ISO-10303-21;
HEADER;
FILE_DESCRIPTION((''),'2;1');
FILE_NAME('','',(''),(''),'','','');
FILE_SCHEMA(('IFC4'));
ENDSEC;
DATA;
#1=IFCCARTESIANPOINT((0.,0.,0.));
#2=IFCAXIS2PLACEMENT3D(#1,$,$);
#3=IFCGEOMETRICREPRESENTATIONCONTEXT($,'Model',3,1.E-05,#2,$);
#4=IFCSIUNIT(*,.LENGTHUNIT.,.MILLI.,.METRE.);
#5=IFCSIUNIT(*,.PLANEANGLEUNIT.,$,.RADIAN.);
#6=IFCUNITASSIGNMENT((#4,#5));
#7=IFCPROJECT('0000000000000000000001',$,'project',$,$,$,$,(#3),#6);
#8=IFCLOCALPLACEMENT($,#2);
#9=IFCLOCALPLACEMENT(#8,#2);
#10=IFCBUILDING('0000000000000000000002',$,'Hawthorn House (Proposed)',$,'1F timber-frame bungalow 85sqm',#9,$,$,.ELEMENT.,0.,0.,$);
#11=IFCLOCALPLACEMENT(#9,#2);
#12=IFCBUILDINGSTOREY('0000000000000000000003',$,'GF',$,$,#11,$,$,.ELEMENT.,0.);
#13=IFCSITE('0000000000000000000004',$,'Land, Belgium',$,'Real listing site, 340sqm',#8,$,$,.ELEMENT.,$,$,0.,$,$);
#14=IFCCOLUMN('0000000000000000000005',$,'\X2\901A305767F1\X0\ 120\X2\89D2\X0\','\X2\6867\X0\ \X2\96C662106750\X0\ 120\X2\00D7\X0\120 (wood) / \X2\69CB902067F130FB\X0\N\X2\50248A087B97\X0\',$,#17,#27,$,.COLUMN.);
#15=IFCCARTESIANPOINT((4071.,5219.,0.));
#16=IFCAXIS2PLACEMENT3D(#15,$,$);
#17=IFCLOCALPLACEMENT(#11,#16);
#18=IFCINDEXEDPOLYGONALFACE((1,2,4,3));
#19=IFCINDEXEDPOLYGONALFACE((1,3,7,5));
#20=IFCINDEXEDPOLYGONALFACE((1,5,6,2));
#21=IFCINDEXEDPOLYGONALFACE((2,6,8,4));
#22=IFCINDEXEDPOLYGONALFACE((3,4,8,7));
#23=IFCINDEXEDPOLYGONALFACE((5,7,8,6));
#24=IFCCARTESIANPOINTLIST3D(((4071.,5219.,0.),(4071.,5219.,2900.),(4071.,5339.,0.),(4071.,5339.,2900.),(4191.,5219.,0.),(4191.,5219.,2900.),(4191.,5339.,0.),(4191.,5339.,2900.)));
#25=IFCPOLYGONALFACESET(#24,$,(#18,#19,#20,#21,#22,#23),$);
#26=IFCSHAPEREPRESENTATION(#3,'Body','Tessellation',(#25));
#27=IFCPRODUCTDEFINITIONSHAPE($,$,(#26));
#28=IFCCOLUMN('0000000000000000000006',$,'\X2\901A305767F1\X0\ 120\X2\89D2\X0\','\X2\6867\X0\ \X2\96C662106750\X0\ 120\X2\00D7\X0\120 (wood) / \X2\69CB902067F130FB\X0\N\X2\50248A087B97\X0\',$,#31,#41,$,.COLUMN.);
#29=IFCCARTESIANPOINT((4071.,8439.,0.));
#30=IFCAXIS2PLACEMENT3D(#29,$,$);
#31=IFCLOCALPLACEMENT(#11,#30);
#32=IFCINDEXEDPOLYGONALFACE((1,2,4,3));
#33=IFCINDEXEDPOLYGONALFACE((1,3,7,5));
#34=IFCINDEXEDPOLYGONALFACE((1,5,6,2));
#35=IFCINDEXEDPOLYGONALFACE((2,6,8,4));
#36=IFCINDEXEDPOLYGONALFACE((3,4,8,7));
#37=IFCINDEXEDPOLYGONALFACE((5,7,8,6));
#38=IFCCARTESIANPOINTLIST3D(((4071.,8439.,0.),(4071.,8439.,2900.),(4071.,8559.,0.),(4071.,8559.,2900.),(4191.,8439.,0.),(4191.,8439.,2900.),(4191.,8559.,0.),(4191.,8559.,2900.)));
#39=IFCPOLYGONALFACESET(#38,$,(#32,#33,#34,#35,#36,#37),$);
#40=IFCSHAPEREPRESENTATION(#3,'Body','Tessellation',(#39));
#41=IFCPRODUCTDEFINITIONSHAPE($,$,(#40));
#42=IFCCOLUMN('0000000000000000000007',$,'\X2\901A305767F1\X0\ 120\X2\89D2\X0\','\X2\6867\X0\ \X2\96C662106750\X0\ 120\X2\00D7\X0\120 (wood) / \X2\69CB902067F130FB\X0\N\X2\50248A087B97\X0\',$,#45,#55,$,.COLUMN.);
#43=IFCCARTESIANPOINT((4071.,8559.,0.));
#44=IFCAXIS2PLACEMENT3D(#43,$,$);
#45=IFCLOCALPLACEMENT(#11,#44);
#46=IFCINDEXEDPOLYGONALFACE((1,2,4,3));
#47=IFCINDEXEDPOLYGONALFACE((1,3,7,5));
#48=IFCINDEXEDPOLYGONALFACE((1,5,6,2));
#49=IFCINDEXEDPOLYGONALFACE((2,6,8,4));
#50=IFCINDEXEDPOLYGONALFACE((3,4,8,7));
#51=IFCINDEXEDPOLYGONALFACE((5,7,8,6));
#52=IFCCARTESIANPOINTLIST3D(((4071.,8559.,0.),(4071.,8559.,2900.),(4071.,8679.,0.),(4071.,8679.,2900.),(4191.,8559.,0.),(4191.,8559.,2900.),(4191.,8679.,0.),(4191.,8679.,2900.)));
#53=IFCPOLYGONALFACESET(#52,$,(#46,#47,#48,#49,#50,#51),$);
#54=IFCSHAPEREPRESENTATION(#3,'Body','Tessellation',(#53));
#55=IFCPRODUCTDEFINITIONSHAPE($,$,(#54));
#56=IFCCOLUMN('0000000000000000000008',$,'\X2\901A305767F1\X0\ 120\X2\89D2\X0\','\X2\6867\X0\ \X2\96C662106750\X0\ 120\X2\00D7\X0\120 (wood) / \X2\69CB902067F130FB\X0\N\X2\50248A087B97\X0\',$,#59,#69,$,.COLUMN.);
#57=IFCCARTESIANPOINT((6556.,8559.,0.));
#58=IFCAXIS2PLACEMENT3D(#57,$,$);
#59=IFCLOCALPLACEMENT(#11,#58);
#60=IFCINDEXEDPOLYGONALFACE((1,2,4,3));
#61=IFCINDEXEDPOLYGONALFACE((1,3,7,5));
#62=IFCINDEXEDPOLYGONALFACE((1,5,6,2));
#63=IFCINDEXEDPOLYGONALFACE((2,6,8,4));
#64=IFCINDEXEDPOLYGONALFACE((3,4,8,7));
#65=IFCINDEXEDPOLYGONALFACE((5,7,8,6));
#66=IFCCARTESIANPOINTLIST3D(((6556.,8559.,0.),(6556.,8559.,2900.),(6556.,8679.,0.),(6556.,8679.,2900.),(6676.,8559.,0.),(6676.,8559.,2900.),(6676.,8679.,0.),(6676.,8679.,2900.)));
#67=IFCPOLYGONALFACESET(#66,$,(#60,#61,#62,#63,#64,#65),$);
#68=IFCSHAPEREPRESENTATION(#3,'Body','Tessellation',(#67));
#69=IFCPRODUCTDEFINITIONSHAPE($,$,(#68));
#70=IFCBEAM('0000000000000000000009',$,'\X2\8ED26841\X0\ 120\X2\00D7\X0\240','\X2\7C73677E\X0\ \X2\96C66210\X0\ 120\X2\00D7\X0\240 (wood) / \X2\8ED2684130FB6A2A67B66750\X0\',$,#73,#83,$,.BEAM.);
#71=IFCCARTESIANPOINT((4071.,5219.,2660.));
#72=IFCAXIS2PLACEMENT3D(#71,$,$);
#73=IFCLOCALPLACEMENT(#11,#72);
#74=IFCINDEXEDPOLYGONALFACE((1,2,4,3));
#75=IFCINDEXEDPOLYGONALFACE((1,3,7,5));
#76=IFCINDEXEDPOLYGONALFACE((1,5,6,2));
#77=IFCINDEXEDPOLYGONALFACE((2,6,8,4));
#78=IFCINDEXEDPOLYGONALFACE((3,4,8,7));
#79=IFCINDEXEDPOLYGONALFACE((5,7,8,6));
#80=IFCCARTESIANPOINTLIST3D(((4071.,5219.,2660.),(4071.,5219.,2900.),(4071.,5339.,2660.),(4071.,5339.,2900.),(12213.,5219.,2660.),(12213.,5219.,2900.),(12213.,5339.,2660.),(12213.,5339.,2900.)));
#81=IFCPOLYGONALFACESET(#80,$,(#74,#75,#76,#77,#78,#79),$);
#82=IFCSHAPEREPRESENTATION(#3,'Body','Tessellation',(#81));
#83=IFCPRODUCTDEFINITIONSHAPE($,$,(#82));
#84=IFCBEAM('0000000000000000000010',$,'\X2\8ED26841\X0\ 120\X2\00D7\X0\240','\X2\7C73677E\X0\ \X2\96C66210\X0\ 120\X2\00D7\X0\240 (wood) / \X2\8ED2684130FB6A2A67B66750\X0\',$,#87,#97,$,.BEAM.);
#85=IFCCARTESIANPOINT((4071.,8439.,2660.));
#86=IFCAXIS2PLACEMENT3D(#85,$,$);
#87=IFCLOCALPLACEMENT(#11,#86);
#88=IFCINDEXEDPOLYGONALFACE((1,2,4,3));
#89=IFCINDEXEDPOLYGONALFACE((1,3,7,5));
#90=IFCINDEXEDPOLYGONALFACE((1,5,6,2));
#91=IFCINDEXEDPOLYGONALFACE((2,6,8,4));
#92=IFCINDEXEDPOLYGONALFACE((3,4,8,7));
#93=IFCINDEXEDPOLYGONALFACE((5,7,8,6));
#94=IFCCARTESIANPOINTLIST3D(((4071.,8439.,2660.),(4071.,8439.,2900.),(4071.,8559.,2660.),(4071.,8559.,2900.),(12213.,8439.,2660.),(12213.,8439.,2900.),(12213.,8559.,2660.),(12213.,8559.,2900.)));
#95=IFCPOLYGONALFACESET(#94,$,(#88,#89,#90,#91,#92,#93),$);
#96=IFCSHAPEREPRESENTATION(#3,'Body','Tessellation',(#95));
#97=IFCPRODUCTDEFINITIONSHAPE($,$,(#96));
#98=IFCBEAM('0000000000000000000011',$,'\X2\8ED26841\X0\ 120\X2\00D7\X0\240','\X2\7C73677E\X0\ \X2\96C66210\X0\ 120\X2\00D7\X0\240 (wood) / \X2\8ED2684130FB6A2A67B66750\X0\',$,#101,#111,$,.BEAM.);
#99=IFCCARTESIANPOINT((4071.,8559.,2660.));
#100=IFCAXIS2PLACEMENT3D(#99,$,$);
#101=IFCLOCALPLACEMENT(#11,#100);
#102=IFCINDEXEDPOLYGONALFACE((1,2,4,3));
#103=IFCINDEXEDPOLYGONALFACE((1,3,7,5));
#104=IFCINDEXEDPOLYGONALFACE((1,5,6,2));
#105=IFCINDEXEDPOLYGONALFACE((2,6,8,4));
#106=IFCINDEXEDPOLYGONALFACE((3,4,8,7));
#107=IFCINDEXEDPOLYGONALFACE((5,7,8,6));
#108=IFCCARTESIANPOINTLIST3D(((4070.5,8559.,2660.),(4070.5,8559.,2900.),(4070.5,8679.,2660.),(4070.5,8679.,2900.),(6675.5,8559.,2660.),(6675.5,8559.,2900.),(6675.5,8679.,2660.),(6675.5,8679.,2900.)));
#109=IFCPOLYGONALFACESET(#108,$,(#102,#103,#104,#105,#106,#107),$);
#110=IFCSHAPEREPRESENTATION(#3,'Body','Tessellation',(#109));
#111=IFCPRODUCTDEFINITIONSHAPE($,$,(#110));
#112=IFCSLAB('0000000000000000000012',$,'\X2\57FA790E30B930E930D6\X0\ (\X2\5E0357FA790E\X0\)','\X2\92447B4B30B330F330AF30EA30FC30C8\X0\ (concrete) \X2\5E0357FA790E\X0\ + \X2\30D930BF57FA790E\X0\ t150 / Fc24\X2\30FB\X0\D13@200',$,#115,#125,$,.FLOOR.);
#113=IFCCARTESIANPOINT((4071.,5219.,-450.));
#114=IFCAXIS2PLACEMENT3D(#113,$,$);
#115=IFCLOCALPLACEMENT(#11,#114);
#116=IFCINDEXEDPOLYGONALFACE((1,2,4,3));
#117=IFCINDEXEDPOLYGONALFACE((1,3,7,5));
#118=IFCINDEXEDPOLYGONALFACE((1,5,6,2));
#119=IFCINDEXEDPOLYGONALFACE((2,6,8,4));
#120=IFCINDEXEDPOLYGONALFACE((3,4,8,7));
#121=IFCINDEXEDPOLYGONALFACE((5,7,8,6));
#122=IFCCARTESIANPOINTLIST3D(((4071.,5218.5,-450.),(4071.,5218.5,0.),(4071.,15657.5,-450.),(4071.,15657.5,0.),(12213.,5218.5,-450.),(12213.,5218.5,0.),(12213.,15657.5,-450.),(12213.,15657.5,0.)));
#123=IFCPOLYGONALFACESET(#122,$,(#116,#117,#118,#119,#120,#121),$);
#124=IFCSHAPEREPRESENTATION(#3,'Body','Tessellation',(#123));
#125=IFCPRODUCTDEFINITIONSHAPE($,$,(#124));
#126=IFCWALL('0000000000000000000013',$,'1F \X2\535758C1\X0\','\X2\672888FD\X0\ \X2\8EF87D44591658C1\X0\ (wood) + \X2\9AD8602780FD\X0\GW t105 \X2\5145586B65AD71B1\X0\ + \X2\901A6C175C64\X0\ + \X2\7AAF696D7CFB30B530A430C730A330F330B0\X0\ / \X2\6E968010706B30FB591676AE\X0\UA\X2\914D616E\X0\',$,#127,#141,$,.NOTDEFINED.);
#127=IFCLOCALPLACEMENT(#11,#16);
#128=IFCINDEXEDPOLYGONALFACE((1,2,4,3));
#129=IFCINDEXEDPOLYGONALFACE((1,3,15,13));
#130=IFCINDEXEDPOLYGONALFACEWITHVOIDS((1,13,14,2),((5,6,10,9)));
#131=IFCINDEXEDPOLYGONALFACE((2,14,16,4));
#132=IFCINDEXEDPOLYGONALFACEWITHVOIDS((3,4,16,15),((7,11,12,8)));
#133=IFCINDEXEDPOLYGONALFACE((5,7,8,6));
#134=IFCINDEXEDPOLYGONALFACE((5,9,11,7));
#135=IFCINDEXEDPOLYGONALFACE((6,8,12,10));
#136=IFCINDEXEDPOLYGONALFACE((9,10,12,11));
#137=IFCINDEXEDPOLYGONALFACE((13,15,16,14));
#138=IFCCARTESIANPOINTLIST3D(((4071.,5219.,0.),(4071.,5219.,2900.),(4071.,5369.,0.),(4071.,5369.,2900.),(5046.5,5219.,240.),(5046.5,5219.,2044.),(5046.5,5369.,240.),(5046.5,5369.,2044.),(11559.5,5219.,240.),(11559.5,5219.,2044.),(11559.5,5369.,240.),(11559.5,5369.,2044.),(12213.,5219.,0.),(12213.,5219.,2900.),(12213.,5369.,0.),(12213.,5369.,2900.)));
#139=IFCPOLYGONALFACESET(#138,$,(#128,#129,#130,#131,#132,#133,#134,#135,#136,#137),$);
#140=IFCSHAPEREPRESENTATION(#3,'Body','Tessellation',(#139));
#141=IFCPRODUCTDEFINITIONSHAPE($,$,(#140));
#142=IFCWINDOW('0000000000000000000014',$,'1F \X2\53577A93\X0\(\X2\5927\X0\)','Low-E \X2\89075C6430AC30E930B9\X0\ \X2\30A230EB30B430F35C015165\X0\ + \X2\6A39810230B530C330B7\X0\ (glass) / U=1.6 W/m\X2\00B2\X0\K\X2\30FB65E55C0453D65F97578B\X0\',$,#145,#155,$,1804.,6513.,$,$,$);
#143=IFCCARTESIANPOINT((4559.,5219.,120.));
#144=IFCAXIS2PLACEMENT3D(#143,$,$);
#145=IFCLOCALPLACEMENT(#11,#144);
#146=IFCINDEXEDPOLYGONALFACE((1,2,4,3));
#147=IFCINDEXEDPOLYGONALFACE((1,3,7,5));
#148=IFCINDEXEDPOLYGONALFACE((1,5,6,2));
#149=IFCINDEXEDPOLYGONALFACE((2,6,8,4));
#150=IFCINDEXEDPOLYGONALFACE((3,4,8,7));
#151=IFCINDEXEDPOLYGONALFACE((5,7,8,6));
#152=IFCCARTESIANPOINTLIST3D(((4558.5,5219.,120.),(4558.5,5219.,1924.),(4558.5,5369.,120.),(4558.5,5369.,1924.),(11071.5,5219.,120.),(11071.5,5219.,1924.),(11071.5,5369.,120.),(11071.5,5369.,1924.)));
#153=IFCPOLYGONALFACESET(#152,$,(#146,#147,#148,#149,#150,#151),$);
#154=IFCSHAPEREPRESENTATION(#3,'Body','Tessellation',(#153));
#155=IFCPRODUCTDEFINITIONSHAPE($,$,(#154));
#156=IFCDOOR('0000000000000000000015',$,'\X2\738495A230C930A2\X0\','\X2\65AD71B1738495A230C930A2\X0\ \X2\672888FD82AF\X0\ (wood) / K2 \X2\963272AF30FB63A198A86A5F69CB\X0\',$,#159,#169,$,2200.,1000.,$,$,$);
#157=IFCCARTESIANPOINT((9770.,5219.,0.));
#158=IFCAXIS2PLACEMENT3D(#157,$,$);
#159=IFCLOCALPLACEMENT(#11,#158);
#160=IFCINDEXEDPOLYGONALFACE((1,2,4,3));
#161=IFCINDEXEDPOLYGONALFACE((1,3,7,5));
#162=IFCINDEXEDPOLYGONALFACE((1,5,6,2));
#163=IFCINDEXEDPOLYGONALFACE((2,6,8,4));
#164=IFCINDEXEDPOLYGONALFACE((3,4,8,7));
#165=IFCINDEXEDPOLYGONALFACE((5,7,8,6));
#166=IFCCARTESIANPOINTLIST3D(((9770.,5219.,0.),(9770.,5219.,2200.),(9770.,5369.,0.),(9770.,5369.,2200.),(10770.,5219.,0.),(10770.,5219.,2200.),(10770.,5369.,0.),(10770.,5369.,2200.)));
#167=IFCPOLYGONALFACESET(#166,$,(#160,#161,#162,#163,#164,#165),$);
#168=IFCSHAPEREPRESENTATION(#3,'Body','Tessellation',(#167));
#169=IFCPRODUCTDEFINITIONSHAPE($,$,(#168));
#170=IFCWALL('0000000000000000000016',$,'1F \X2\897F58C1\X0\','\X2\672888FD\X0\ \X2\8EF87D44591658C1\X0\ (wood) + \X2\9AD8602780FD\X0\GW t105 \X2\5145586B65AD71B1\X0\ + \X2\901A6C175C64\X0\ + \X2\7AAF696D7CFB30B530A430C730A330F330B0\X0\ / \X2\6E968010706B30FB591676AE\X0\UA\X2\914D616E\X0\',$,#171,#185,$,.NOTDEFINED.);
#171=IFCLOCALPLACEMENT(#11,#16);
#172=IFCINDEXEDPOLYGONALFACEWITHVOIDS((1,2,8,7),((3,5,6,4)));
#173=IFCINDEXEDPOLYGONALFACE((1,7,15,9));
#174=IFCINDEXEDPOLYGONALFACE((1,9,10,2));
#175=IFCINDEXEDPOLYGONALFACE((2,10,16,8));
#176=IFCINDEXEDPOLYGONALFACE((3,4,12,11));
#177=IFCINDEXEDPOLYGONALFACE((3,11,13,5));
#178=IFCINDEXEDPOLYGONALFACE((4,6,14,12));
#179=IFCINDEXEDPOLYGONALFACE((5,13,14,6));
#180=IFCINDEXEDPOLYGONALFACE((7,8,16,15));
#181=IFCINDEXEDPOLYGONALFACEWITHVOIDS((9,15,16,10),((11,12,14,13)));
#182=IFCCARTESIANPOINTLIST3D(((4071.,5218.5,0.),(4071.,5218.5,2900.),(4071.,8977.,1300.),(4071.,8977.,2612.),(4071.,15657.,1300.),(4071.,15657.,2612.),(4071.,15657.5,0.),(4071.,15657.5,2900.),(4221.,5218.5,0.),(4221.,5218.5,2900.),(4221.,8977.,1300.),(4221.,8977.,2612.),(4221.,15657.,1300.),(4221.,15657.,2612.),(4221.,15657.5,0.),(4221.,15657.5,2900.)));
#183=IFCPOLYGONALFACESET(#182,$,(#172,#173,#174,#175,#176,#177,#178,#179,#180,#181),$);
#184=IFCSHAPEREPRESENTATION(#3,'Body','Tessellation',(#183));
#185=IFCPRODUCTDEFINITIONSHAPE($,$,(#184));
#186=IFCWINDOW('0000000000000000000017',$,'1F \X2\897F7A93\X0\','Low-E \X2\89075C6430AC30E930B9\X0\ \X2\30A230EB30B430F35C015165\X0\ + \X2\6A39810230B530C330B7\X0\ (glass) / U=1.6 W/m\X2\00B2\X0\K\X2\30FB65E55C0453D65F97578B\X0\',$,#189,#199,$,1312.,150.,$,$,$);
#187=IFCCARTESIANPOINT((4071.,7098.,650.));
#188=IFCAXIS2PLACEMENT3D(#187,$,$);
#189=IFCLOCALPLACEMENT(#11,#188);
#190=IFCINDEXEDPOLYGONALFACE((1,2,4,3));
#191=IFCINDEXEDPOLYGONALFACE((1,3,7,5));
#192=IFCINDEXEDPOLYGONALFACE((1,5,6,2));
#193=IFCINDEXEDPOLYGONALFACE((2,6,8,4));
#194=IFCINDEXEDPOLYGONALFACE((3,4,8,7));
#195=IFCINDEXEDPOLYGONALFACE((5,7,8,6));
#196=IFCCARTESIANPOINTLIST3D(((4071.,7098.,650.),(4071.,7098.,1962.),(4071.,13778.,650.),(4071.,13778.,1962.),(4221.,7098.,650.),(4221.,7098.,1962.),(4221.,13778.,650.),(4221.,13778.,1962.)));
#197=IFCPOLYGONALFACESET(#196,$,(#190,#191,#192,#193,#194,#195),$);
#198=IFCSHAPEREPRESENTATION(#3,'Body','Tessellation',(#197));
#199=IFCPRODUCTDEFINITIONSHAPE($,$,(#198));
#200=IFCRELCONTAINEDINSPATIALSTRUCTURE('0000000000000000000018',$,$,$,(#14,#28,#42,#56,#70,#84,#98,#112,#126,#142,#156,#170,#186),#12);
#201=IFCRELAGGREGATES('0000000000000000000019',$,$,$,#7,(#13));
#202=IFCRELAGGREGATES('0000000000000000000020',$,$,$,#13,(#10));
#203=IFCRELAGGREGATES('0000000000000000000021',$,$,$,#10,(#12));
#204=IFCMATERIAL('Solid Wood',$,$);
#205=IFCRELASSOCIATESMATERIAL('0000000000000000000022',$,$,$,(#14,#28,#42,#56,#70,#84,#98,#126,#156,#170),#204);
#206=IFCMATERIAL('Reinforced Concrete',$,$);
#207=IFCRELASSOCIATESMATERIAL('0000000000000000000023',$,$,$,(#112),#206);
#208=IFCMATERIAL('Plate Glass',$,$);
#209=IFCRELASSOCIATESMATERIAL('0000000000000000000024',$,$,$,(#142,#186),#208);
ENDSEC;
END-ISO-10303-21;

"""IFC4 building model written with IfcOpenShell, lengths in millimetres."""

from ifc_helpers import new_model, si_unit, frame, frame_2d, origin, place, context, project, spatial, rectangle, extrude, material, element, fill, save


model = new_model("IFC4")

# Units and contexts
model_context = context("Model", 3, precision=1e-05, world=origin())
ifc_project = project(units=[si_unit("LENGTHUNIT", "METRE", prefix="MILLI"), si_unit("PLANEANGLEUNIT", "RADIAN")], contexts=[model_context])

# Site, building, storey
site_placement = place(None, origin())
site = spatial("IfcSite", under=ifc_project, at=site_placement, Name="Land, Belgium", ObjectType="Real listing site, 340sqm", CompositionType="ELEMENT", RefElevation=0.0)
building_placement = place(site_placement, origin())
building = spatial("IfcBuilding", under=site, at=building_placement, Name="Hawthorn House (Proposed)", ObjectType="1F timber-frame bungalow 85sqm", CompositionType="ELEMENT", ElevationOfRefHeight=0.0, ElevationOfTerrain=0.0)
storey_placement = place(building_placement, origin())
storey = spatial("IfcBuildingStorey", under=building, at=storey_placement, Name="GF", CompositionType="ELEMENT", Elevation=0.0)

# Columns
ifc_material_1 = material(Name="Solid Wood")
column_1_placement = place(storey_placement, frame((4071.0, 5219.0, 0.0)))
element("IfcColumn", 1, at=column_1_placement, inside=storey, material=ifc_material_1, Name="通し柱 120角", Description="桧 集成材 120×120 (wood) / 構造柱・N値計算", PredefinedType="COLUMN", context=model_context, shape_type="SweptSolid", body=[
    extrude(rectangle(XDim=120.0, YDim=120.0, at=frame_2d((60.0, 60.0))), frame((4071.0, 5219.0, 0.0)), (0.0, 0.0, 1.0), 2900.0),
])
column_2_placement = place(storey_placement, frame((4071.0, 8439.0, 0.0)))
element("IfcColumn", 2, at=column_2_placement, inside=storey, material=ifc_material_1, Name="通し柱 120角", Description="桧 集成材 120×120 (wood) / 構造柱・N値計算", PredefinedType="COLUMN", context=model_context, shape_type="SweptSolid", body=[
    extrude(rectangle(XDim=120.0, YDim=120.0, at=frame_2d((60.0, 60.0))), frame((4071.0, 8439.0, 0.0)), (0.0, 0.0, 1.0), 2900.0),
])
column_3_placement = place(storey_placement, frame((4071.0, 8559.0, 0.0)))
element("IfcColumn", 3, at=column_3_placement, inside=storey, material=ifc_material_1, Name="通し柱 120角", Description="桧 集成材 120×120 (wood) / 構造柱・N値計算", PredefinedType="COLUMN", context=model_context, shape_type="SweptSolid", body=[
    extrude(rectangle(XDim=120.0, YDim=120.0, at=frame_2d((60.0, 60.0))), frame((4071.0, 8559.0, 0.0)), (0.0, 0.0, 1.0), 2900.0),
])
column_4_placement = place(storey_placement, frame((6556.0, 8559.0, 0.0)))
element("IfcColumn", 4, at=column_4_placement, inside=storey, material=ifc_material_1, Name="通し柱 120角", Description="桧 集成材 120×120 (wood) / 構造柱・N値計算", PredefinedType="COLUMN", context=model_context, shape_type="SweptSolid", body=[
    extrude(rectangle(XDim=120.0, YDim=120.0, at=frame_2d((60.0, 60.0))), frame((6556.0, 8559.0, 0.0)), (0.0, 0.0, 1.0), 2900.0),
])

# Beams
beam_1_placement = place(storey_placement, frame((4071.0, 5219.0, 2660.0)))
element("IfcBeam", 5, at=beam_1_placement, inside=storey, material=ifc_material_1, Name="軒桁 120×240", Description="米松 集成 120×240 (wood) / 軒桁・横架材", PredefinedType="BEAM", context=model_context, shape_type="SweptSolid", body=[
    extrude(rectangle(XDim=8142.0, YDim=120.0, at=frame_2d((4071.0, 60.0))), frame((4071.0, 5219.0, 2660.0)), (0.0, 0.0, 1.0), 240.0),
])
beam_2_placement = place(storey_placement, frame((4071.0, 8439.0, 2660.0)))
element("IfcBeam", 6, at=beam_2_placement, inside=storey, material=ifc_material_1, Name="軒桁 120×240", Description="米松 集成 120×240 (wood) / 軒桁・横架材", PredefinedType="BEAM", context=model_context, shape_type="SweptSolid", body=[
    extrude(rectangle(XDim=8142.0, YDim=120.0, at=frame_2d((4071.0, 60.0))), frame((4071.0, 8439.0, 2660.0)), (0.0, 0.0, 1.0), 240.0),
])
beam_3_placement = place(storey_placement, frame((4071.0, 8559.0, 2660.0)))
element("IfcBeam", 7, at=beam_3_placement, inside=storey, material=ifc_material_1, Name="軒桁 120×240", Description="米松 集成 120×240 (wood) / 軒桁・横架材", PredefinedType="BEAM", context=model_context, shape_type="SweptSolid", body=[
    extrude(rectangle(XDim=2605.0, YDim=120.0, at=frame_2d((1302.0, 60.0))), frame((4071.0, 8559.0, 2660.0)), (0.0, 0.0, 1.0), 240.0),
])

# Slab
ifc_material_2 = material(Name="Reinforced Concrete")
slab_1_placement = place(storey_placement, frame((4071.0, 5219.0, -450.0)))
element("IfcSlab", 8, at=slab_1_placement, inside=storey, material=ifc_material_2, Name="基礎スラブ (布基礎)", Description="鉄筋コンクリート (concrete) 布基礎 + ベタ基礎 t150 / Fc24・D13@200", PredefinedType="FLOOR", context=model_context, shape_type="SweptSolid", body=[
    extrude(rectangle(XDim=8142.0, YDim=10439.0, at=frame_2d((4071.0, 5219.0))), frame((4071.0, 5219.0, -450.0)), (0.0, 0.0, 1.0), 450.0),
])

# Wall, openings, window, door
wall_1_placement = place(storey_placement, frame((4071.0, 5219.0, 0.0)))
wall_1 = element("IfcWall", 9, at=wall_1_placement, inside=storey, material=ifc_material_1, Name="1F 南壁", Description="木製 軸組外壁 (wood) + 高性能GW t105 充填断熱 + 通気層 + 窯業系サイディング / 準耐火・外皮UA配慮", PredefinedType="NOTDEFINED", context=model_context, shape_type="SweptSolid", body=[
    extrude(rectangle(XDim=8142.0, YDim=150.0, at=frame_2d((4071.0, 75.0))), frame((4071.0, 5219.0, 0.0)), (0.0, 0.0, 1.0), 2900.0),
])
opening_1_placement = place(storey_placement, frame((4559.0, 5219.0, 120.0)))
opening_1 = element("IfcOpeningElement", 10, at=opening_1_placement, cuts=wall_1, PredefinedType="NOTDEFINED", context=model_context, shape_type="SweptSolid", body=[
    extrude(rectangle(XDim=6513.0, YDim=150.0, at=frame_2d((3256.0, 75.0))), frame((4559.0, 5219.0, 120.0)), (0.0, 0.0, 1.0), 1804.0),
])
opening_2_placement = place(storey_placement, frame((9770.0, 5219.0, 0.0)))
opening_2 = element("IfcOpeningElement", 11, at=opening_2_placement, cuts=wall_1, PredefinedType="NOTDEFINED", context=model_context, shape_type="SweptSolid", body=[
    extrude(rectangle(XDim=1000.0, YDim=150.0, at=frame_2d((500.0, 75.0))), frame((9770.0, 5219.0, 0.0)), (0.0, 0.0, 1.0), 2200.0),
])
ifc_material_3 = material(Name="Plate Glass")
window_1_placement = place(storey_placement, frame((4559.0, 5219.0, 120.0)))
window_1 = element("IfcWindow", 12, at=window_1_placement, inside=storey, material=ifc_material_3, Name="1F 南窓(大)", Description="Low-E 複層ガラス アルゴン封入 + 樹脂サッシ (glass) / U=1.6 W/m²K・日射取得型", OverallHeight=1804.0, OverallWidth=6513.0, context=model_context, shape_type="SweptSolid", body=[
    extrude(rectangle(XDim=6513.0, YDim=150.0, at=frame_2d((3256.0, 75.0))), frame((4559.0, 5219.0, 120.0)), (0.0, 0.0, 1.0), 1804.0),
])
fill(opening_1, window_1)
door_placement = place(storey_placement, frame((9770.0, 5219.0, 0.0)))
door = element("IfcDoor", 13, at=door_placement, inside=storey, material=ifc_material_1, Name="玄関ドア", Description="断熱玄関ドア 木製芯 (wood) / K2 防犯・採風機構", OverallHeight=2200.0, OverallWidth=1000.0, context=model_context, shape_type="SweptSolid", body=[
    extrude(rectangle(XDim=1000.0, YDim=150.0, at=frame_2d((500.0, 75.0))), frame((9770.0, 5219.0, 0.0)), (0.0, 0.0, 1.0), 2200.0),
])
fill(opening_2, door)

# Wall, opening, window
wall_2_placement = place(storey_placement, frame((4071.0, 5219.0, 0.0)))
wall_2 = element("IfcWall", 14, at=wall_2_placement, inside=storey, material=ifc_material_1, Name="1F 西壁", Description="木製 軸組外壁 (wood) + 高性能GW t105 充填断熱 + 通気層 + 窯業系サイディング / 準耐火・外皮UA配慮", PredefinedType="NOTDEFINED", context=model_context, shape_type="SweptSolid", body=[
    extrude(rectangle(XDim=150.0, YDim=10439.0, at=frame_2d((75.0, 5219.0))), frame((4071.0, 5219.0, 0.0)), (0.0, 0.0, 1.0), 2900.0),
])
opening_3_placement = place(storey_placement, frame((4071.0, 7098.0, 650.0)))
opening_3 = element("IfcOpeningElement", 15, at=opening_3_placement, cuts=wall_2, PredefinedType="NOTDEFINED", context=model_context, shape_type="SweptSolid", body=[
    extrude(rectangle(XDim=150.0, YDim=6680.0, at=frame_2d((75.0, 3340.0))), frame((4071.0, 7098.0, 650.0)), (0.0, 0.0, 1.0), 1312.0),
])
window_2_placement = place(storey_placement, frame((4071.0, 7098.0, 650.0)))
window_2 = element("IfcWindow", 16, at=window_2_placement, inside=storey, material=ifc_material_3, Name="1F 西窓", Description="Low-E 複層ガラス アルゴン封入 + 樹脂サッシ (glass) / U=1.6 W/m²K・日射取得型", OverallHeight=1312.0, OverallWidth=150.0, context=model_context, shape_type="SweptSolid", body=[
    extrude(rectangle(XDim=150.0, YDim=6680.0, at=frame_2d((75.0, 3340.0))), frame((4071.0, 7098.0, 650.0)), (0.0, 0.0, 1.0), 1312.0),
])
fill(opening_3, window_2)

save(model, "model.ifc")
